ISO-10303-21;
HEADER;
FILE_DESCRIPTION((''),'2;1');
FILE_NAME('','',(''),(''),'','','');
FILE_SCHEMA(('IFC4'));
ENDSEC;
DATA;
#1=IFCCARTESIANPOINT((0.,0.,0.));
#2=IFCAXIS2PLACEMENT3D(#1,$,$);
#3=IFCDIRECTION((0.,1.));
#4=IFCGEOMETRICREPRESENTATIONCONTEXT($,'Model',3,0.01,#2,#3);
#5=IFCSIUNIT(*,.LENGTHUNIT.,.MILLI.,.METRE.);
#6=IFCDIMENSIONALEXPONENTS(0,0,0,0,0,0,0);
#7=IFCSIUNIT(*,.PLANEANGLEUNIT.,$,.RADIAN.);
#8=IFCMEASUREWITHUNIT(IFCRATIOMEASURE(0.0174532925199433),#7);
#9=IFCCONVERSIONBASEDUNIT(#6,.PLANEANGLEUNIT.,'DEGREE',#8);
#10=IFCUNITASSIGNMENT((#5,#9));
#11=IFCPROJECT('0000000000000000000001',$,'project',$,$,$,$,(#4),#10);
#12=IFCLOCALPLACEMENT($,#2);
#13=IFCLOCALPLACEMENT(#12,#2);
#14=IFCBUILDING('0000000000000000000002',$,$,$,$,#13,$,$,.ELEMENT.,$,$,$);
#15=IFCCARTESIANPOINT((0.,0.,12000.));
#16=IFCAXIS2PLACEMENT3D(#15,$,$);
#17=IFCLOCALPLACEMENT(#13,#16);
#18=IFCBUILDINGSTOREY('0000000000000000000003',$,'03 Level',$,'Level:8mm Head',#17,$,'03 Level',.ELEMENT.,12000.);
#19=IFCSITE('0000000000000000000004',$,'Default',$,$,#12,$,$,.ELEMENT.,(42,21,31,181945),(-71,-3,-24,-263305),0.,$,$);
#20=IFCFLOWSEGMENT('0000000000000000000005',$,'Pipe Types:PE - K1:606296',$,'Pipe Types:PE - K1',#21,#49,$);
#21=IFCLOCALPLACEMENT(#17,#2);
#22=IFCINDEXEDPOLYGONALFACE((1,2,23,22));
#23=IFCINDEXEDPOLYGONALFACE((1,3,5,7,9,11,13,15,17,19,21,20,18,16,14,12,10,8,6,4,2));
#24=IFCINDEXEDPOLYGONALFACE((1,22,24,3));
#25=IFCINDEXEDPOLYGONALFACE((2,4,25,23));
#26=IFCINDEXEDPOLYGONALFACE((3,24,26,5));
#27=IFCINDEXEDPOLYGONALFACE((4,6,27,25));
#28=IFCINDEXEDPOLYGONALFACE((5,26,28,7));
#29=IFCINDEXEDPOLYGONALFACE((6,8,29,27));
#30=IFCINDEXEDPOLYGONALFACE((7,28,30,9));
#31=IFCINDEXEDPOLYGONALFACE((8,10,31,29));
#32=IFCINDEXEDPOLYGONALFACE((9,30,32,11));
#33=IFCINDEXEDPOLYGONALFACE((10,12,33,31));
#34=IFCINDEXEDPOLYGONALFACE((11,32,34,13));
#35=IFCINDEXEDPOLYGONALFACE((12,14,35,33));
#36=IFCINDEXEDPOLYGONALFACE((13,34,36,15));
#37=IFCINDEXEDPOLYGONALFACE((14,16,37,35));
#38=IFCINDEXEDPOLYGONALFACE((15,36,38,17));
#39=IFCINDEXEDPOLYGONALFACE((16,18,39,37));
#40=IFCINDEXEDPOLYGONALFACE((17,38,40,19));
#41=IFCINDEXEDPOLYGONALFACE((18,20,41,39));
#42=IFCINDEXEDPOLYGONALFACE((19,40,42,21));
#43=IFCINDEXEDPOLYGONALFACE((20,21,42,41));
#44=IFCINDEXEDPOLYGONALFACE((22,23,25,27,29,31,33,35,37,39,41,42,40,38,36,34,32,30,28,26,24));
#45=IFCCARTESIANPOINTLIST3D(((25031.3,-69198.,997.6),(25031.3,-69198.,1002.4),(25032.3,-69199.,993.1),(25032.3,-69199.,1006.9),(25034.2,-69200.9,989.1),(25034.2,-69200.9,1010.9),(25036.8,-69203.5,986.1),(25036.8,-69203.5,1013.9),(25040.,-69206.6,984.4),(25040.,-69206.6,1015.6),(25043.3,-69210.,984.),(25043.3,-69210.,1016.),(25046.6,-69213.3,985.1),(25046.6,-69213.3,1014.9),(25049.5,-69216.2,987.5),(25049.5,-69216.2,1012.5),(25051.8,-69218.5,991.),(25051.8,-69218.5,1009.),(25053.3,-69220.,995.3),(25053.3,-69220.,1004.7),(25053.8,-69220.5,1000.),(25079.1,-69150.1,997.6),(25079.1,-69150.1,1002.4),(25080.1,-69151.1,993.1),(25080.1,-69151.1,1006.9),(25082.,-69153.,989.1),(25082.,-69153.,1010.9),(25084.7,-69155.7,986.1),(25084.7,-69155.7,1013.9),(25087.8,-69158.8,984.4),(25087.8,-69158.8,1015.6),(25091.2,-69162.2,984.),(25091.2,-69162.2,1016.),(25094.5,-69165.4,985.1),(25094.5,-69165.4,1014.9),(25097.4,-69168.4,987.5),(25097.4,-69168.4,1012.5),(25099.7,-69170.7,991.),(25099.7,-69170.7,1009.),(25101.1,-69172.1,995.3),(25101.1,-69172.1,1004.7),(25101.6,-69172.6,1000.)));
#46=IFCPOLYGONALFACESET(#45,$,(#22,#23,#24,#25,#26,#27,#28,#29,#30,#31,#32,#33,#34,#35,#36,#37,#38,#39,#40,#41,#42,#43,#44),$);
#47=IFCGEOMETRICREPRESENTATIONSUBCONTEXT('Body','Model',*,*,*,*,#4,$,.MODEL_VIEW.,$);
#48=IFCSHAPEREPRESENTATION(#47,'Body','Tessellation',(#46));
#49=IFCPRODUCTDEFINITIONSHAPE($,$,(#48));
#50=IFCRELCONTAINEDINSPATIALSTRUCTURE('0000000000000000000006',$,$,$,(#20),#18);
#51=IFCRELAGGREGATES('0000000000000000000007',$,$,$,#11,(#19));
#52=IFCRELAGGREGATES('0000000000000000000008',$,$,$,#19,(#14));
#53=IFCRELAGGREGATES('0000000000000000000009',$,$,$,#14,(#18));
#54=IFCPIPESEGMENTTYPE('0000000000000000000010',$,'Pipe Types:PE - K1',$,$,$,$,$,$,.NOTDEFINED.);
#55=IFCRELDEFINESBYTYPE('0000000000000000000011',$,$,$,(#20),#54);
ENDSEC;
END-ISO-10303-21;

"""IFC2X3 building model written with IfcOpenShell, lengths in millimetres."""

from ifc_helpers import new_model, entity, si_unit, converted_unit, direction, frame, origin, origin_2d_with_axis, place, context, subcontext, project, spatial, circle, extrude, type_object, element, save


model = new_model("IFC2X3")

# Units and contexts
model_context = context("Model", 3, precision=0.01, world=origin(), true_north=direction((0.0, 1.0)))
body_context = subcontext(model_context, "Body", "Model", "MODEL_VIEW")
ifc_project = project(units=[si_unit("LENGTHUNIT", "METRE", prefix="MILLI"), converted_unit("PLANEANGLEUNIT", "DEGREE", entity("IfcRatioMeasure", 0.0174532925199433), si_unit("PLANEANGLEUNIT", "RADIAN"), dimensions=[0, 0, 0, 0, 0, 0, 0])], contexts=[model_context])

# Site, building, storey
site_placement = place(None, origin())
site = spatial("IfcSite", under=ifc_project, at=site_placement, Name="Default", CompositionType="ELEMENT", RefLatitude=(42, 21, 31, 181945), RefLongitude=(-71, -3, -24, -263305), RefElevation=0.0)
building_placement = place(site_placement, origin())
building = spatial("IfcBuilding", under=site, at=building_placement, CompositionType="ELEMENT")
storey_placement = place(building_placement, frame((0.0, 0.0, 12000.0)))
storey = spatial("IfcBuildingStorey", under=building, at=storey_placement, Name="03 Level", ObjectType="Level:8mm Head", LongName="03 Level", CompositionType="ELEMENT", Elevation=12000.0)

# Flow segment
pipe_segment_type = type_object("IfcPipeSegmentType", Name="Pipe Types:PE - K1", PredefinedType="NOTDEFINED")
flow_segment_1_placement = place(storey_placement, frame((25029.6, -69222.1, 982.4)))
element("IfcFlowSegment", 1, at=flow_segment_1_placement, inside=storey, type_object=pipe_segment_type, Name="Pipe Types:PE - K1:606296", ObjectType="Pipe Types:PE - K1", context=body_context, shape_type="SweptSolid", body=[
    extrude(circle(Radius=16.0, at=origin_2d_with_axis()), frame((12.9, 12.9, 17.6), z_axis=(0.707107, 0.707107, 0.0), x_axis=(0.707107, -0.707107, 0.0)), (0.0, 0.0, 1.0), 67.6),
])

save(model, "model.ifc")
